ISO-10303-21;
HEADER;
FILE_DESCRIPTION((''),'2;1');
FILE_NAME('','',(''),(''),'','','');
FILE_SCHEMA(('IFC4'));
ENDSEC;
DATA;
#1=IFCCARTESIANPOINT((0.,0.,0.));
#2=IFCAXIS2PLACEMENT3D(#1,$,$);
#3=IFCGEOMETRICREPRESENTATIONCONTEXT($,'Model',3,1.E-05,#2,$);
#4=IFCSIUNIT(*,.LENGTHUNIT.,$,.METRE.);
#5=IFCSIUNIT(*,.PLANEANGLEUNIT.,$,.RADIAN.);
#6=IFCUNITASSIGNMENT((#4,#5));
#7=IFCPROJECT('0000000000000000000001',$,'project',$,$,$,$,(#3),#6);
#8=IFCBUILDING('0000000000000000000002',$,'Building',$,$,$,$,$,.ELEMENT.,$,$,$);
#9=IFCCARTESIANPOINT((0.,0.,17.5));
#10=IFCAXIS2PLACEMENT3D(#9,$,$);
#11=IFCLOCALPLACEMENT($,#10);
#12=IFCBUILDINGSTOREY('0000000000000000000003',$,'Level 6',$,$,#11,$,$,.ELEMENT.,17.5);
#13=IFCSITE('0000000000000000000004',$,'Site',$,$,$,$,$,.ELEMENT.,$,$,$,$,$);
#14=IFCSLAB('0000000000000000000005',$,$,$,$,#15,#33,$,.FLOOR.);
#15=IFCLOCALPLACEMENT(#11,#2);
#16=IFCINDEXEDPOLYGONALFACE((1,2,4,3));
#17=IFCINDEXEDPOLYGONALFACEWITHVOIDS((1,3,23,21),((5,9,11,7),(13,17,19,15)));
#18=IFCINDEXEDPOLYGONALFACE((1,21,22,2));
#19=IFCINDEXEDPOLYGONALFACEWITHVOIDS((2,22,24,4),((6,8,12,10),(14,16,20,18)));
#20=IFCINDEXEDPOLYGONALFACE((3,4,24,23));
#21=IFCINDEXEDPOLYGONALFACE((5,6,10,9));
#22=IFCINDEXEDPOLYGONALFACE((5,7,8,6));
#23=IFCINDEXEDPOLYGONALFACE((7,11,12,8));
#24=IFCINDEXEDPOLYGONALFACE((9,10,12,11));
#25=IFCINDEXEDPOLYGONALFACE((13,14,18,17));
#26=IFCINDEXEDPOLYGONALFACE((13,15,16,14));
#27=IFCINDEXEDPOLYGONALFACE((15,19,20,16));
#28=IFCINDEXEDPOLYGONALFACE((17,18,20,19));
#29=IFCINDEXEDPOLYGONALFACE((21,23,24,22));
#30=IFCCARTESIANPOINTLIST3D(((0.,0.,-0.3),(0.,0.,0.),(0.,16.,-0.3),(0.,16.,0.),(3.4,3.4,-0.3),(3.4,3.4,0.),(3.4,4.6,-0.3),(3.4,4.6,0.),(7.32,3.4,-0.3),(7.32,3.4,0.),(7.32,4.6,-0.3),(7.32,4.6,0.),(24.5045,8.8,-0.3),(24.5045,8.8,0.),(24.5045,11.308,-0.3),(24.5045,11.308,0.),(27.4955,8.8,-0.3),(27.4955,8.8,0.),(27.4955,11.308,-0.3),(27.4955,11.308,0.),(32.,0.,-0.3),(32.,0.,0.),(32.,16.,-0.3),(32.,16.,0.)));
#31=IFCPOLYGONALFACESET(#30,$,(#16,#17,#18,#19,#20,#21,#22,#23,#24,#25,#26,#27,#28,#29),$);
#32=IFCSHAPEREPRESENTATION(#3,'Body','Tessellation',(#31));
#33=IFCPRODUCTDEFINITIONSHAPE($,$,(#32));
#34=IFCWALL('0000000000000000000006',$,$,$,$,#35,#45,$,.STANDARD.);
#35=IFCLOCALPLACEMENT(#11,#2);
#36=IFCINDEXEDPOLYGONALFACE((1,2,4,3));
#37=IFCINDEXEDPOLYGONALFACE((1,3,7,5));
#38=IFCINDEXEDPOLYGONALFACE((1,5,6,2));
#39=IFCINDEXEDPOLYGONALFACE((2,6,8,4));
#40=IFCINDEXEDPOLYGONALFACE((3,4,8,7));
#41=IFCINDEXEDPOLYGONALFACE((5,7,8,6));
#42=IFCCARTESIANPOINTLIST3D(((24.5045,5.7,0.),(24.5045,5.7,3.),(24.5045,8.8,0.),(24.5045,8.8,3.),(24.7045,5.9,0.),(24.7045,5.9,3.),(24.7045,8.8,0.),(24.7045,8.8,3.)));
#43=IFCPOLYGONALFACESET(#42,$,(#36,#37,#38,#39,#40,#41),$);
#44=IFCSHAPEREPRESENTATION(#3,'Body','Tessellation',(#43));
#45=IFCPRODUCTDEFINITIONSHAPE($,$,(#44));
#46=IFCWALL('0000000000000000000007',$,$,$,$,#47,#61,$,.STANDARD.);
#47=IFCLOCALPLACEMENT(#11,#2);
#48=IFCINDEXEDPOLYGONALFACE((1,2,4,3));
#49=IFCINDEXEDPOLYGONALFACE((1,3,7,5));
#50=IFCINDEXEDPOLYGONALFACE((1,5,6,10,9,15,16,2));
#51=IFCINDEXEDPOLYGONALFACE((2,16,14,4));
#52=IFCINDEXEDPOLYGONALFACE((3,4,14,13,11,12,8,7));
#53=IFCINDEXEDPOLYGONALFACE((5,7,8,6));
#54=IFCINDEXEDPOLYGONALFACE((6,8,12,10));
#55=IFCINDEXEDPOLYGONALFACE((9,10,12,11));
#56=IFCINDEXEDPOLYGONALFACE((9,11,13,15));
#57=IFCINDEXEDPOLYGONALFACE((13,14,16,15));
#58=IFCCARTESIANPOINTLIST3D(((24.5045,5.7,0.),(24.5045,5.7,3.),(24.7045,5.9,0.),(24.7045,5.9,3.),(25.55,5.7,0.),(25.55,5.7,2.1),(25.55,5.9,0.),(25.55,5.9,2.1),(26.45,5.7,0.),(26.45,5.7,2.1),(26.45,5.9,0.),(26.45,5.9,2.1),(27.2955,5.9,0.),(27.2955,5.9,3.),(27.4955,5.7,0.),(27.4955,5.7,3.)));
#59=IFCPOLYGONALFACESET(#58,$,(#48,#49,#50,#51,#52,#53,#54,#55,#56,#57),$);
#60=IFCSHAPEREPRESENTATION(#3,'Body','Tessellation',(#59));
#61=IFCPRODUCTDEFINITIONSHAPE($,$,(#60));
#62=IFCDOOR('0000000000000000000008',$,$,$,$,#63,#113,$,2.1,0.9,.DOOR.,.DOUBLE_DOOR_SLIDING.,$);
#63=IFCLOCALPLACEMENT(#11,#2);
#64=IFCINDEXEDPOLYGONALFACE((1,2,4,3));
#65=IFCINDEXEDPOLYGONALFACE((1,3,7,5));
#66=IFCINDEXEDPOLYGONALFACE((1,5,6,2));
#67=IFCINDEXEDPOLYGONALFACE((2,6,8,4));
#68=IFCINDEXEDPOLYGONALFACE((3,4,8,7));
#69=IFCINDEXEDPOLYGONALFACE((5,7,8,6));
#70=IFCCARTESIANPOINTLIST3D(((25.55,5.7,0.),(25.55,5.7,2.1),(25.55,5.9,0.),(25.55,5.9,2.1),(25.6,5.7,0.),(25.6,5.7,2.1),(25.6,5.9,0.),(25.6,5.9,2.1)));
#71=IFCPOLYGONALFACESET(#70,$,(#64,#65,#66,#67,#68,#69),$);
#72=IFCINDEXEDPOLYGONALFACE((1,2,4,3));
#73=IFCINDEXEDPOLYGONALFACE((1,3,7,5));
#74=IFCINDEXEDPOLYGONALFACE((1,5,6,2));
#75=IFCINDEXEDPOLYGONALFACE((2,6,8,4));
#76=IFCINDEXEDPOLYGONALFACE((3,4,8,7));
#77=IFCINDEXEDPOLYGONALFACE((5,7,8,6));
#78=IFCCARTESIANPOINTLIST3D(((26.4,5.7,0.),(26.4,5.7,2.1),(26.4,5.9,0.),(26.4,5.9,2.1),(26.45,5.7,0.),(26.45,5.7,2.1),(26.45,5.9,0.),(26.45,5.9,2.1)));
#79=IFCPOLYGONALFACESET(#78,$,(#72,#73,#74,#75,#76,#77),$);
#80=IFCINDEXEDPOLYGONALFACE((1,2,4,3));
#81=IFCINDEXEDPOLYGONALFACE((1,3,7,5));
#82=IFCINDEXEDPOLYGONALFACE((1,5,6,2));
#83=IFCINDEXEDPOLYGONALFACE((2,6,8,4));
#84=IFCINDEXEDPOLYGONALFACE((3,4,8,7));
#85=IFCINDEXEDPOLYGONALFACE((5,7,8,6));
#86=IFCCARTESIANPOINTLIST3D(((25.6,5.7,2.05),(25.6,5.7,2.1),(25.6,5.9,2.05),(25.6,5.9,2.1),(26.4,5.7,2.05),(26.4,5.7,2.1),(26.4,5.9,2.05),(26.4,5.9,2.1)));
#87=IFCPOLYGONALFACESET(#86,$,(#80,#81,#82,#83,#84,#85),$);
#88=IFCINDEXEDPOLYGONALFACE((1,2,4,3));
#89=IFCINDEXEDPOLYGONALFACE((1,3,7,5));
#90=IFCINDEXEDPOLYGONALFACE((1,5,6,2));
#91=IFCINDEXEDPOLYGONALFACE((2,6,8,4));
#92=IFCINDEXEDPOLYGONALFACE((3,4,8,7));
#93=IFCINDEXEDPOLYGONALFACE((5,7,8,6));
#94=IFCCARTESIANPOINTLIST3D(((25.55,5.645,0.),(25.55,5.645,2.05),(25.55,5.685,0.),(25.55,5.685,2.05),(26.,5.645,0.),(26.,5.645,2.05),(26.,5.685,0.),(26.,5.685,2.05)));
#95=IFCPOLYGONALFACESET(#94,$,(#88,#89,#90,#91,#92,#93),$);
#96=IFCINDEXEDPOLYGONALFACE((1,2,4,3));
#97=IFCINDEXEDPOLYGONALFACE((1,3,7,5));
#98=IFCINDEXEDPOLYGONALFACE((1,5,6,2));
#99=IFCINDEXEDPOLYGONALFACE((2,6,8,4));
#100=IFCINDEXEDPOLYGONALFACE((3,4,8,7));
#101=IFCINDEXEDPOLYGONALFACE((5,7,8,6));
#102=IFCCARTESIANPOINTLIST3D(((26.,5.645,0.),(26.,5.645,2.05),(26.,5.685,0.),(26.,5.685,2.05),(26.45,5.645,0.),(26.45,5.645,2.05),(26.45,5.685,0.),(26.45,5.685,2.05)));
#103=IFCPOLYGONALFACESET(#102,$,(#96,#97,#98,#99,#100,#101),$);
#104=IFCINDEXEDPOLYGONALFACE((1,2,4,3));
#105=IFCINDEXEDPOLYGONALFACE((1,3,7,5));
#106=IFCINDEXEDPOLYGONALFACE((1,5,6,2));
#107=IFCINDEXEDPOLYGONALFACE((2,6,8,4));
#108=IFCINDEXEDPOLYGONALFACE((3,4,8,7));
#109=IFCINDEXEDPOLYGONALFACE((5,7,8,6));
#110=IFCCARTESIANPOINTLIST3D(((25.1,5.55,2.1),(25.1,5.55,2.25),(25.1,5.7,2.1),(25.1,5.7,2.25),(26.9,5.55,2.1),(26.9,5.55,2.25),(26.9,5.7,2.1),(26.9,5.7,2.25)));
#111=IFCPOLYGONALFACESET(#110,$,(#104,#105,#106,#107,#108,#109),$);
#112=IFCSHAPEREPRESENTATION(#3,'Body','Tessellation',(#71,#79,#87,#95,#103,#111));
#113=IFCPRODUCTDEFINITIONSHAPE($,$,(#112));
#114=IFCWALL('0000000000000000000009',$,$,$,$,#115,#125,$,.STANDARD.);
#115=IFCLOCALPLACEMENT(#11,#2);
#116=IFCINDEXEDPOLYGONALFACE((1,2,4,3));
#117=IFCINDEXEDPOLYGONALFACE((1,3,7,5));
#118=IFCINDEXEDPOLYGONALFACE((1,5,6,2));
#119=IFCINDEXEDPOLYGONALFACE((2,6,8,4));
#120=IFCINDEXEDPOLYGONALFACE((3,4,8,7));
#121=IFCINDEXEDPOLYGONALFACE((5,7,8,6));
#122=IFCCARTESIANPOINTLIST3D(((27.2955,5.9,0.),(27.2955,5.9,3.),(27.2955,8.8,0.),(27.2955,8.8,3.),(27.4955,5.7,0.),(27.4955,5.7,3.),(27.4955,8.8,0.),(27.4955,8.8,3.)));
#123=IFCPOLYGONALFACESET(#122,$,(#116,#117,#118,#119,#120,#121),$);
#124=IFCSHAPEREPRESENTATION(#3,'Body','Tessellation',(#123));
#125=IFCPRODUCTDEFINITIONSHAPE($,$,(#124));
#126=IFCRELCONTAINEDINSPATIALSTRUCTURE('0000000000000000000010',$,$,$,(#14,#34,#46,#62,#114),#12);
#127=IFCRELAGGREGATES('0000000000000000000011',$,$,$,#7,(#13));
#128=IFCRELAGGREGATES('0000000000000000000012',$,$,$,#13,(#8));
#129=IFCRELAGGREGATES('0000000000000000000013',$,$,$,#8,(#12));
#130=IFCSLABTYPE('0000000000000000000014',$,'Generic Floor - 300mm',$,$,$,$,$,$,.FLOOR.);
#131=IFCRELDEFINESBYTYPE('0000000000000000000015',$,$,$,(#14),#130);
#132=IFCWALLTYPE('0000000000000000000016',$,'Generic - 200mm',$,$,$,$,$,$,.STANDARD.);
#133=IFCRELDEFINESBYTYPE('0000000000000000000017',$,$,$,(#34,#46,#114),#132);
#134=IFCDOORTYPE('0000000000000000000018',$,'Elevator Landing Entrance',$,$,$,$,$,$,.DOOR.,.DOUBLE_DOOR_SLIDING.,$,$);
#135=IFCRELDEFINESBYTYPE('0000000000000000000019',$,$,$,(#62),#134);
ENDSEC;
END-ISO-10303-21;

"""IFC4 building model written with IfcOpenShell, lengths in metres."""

from ifc_helpers import new_model, si_unit, frame, frame_2d, origin, origin_with_axes, origin_2d, place, context, project, spatial, polyline, rectangle, outline, extrude, type_object, element, fill, save


model = new_model("IFC4")

# Units and contexts
model_context = context("Model", 3, precision=1e-05, world=origin())
ifc_project = project(units=[si_unit("LENGTHUNIT", "METRE"), si_unit("PLANEANGLEUNIT", "RADIAN")], contexts=[model_context])

# Site, building, storey
site = spatial("IfcSite", under=ifc_project, Name="Site", CompositionType="ELEMENT")
building = spatial("IfcBuilding", under=site, Name="Building", CompositionType="ELEMENT")
storey_placement = place(None, frame((0.0, 0.0, 17.5)))
storey = spatial("IfcBuildingStorey", under=building, at=storey_placement, Name="Level 6", CompositionType="ELEMENT", Elevation=17.5)

# Slab, openings
slab_type = type_object("IfcSlabType", Name="Generic Floor - 300mm", PredefinedType="FLOOR")
slab_placement = place(None, frame((0.0, 0.0, 17.5)))
slab = element("IfcSlab", 1, at=slab_placement, inside=storey, type_object=slab_type, PredefinedType="FLOOR", context=model_context, shape_type="SweptSolid", body=[
    extrude(outline(polyline([(0.0, 0.0), (32.0, 0.0), (32.0, 16.0), (0.0, 16.0), (0.0, 0.0)])), origin(), (0.0, 0.0, -1.0), 0.3),
])
opening_1_placement = place(None, frame((0.0, 0.0, 17.501)))
element("IfcOpeningElement", 2, at=opening_1_placement, cuts=slab, PredefinedType="OPENING", context=model_context, shape_type="SweptSolid", body=[
    extrude(outline(polyline([(3.4, 4.6), (3.4, 3.4), (7.32, 3.4), (7.32, 4.6), (3.4, 4.6)])), origin(), (0.0, 0.0, -1.0), 0.302),
])
opening_2_placement = place(None, frame((0.0, 0.0, 17.501)))
element("IfcOpeningElement", 3, at=opening_2_placement, cuts=slab, PredefinedType="OPENING", context=model_context, shape_type="SweptSolid", body=[
    extrude(outline(polyline([(24.5045, 8.8), (27.4955, 8.8), (27.4955, 11.308), (24.5045, 11.308), (24.5045, 8.8)])), origin(), (0.0, 0.0, -1.0), 0.302),
])

# Wall
wall_type = type_object("IfcWallType", Name="Generic - 200mm", PredefinedType="STANDARD")
wall_1_placement = place(None, frame((24.6045, 8.8, 17.5), z_axis=(0.0, 0.0, 1.0), x_axis=(0.0, -1.0, 0.0)))
element("IfcWall", 4, at=wall_1_placement, inside=storey, type_object=wall_type, PredefinedType="STANDARD", context=model_context, shape_type="SweptSolid", body=[
    extrude(outline(polyline([(0.0, -0.1), (3.1, -0.1), (2.9, 0.1), (0.0, 0.1), (0.0, -0.1)])), origin(), (0.0, 0.0, 1.0), 3.0),
])

# Wall, opening, door
wall_2_placement = place(None, frame((24.6045, 5.8, 17.5), z_axis=(0.0, 0.0, 1.0), x_axis=(1.0, 0.0, 0.0)))
wall_2 = element("IfcWall", 5, at=wall_2_placement, inside=storey, type_object=wall_type, PredefinedType="STANDARD", context=model_context, shape_type="SweptSolid", body=[
    extrude(outline(polyline([(-0.1, -0.1), (2.891, -0.1), (2.691, 0.1), (0.1, 0.1), (-0.1, -0.1)])), origin(), (0.0, 0.0, 1.0), 3.0),
])
opening_3_placement = place(wall_2_placement, frame((1.3955, 0.0, 0.0), z_axis=(0.0, 0.0, 1.0), x_axis=(1.0, 0.0, 0.0)))
opening_3 = element("IfcOpeningElement", 6, at=opening_3_placement, cuts=wall_2, PredefinedType="OPENING", context=model_context, shape_type="SweptSolid", body=[
    extrude(rectangle(XDim=0.9, YDim=0.202, at=origin_2d()), origin(), (0.0, 0.0, 1.0), 2.1),
])
door_type = type_object("IfcDoorType", Name="Elevator Landing Entrance", OperationType="DOUBLE_DOOR_SLIDING", PredefinedType="DOOR")
door_placement = place(opening_3_placement, origin_with_axes())
door = element("IfcDoor", 7, at=door_placement, inside=storey, type_object=door_type, OperationType="DOUBLE_DOOR_SLIDING", OverallHeight=2.1, OverallWidth=0.9, PredefinedType="DOOR", context=model_context, shape_type="SweptSolid", body=[
    extrude(rectangle(XDim=0.05, YDim=0.2, at=frame_2d((-0.425, 0.0))), origin(), (0.0, 0.0, 1.0), 2.1),
    extrude(rectangle(XDim=0.05, YDim=0.2, at=frame_2d((0.425, 0.0))), origin(), (0.0, 0.0, 1.0), 2.1),
    extrude(rectangle(XDim=0.8, YDim=0.2, at=origin_2d()), frame((0.0, 0.0, 2.05)), (0.0, 0.0, 1.0), 0.05),
    extrude(rectangle(XDim=0.45, YDim=0.04, at=frame_2d((-0.225, -0.135))), origin(), (0.0, 0.0, 1.0), 2.05),
    extrude(rectangle(XDim=0.45, YDim=0.04, at=frame_2d((0.225, -0.135))), origin(), (0.0, 0.0, 1.0), 2.05),
    extrude(rectangle(XDim=1.8, YDim=0.15, at=frame_2d((0.0, -0.175))), frame((0.0, 0.0, 2.1)), (0.0, 0.0, 1.0), 0.15),
])
fill(opening_3, door)

# Wall
wall_3_placement = place(None, frame((27.3955, 5.8, 17.5), z_axis=(0.0, 0.0, 1.0), x_axis=(0.0, 1.0, 0.0)))
element("IfcWall", 8, at=wall_3_placement, inside=storey, type_object=wall_type, PredefinedType="STANDARD", context=model_context, shape_type="SweptSolid", body=[
    extrude(outline(polyline([(-0.1, -0.1), (3.0, -0.1), (3.0, 0.1), (0.1, 0.1), (-0.1, -0.1)])), origin(), (0.0, 0.0, 1.0), 3.0),
])

save(model, "model.ifc")
